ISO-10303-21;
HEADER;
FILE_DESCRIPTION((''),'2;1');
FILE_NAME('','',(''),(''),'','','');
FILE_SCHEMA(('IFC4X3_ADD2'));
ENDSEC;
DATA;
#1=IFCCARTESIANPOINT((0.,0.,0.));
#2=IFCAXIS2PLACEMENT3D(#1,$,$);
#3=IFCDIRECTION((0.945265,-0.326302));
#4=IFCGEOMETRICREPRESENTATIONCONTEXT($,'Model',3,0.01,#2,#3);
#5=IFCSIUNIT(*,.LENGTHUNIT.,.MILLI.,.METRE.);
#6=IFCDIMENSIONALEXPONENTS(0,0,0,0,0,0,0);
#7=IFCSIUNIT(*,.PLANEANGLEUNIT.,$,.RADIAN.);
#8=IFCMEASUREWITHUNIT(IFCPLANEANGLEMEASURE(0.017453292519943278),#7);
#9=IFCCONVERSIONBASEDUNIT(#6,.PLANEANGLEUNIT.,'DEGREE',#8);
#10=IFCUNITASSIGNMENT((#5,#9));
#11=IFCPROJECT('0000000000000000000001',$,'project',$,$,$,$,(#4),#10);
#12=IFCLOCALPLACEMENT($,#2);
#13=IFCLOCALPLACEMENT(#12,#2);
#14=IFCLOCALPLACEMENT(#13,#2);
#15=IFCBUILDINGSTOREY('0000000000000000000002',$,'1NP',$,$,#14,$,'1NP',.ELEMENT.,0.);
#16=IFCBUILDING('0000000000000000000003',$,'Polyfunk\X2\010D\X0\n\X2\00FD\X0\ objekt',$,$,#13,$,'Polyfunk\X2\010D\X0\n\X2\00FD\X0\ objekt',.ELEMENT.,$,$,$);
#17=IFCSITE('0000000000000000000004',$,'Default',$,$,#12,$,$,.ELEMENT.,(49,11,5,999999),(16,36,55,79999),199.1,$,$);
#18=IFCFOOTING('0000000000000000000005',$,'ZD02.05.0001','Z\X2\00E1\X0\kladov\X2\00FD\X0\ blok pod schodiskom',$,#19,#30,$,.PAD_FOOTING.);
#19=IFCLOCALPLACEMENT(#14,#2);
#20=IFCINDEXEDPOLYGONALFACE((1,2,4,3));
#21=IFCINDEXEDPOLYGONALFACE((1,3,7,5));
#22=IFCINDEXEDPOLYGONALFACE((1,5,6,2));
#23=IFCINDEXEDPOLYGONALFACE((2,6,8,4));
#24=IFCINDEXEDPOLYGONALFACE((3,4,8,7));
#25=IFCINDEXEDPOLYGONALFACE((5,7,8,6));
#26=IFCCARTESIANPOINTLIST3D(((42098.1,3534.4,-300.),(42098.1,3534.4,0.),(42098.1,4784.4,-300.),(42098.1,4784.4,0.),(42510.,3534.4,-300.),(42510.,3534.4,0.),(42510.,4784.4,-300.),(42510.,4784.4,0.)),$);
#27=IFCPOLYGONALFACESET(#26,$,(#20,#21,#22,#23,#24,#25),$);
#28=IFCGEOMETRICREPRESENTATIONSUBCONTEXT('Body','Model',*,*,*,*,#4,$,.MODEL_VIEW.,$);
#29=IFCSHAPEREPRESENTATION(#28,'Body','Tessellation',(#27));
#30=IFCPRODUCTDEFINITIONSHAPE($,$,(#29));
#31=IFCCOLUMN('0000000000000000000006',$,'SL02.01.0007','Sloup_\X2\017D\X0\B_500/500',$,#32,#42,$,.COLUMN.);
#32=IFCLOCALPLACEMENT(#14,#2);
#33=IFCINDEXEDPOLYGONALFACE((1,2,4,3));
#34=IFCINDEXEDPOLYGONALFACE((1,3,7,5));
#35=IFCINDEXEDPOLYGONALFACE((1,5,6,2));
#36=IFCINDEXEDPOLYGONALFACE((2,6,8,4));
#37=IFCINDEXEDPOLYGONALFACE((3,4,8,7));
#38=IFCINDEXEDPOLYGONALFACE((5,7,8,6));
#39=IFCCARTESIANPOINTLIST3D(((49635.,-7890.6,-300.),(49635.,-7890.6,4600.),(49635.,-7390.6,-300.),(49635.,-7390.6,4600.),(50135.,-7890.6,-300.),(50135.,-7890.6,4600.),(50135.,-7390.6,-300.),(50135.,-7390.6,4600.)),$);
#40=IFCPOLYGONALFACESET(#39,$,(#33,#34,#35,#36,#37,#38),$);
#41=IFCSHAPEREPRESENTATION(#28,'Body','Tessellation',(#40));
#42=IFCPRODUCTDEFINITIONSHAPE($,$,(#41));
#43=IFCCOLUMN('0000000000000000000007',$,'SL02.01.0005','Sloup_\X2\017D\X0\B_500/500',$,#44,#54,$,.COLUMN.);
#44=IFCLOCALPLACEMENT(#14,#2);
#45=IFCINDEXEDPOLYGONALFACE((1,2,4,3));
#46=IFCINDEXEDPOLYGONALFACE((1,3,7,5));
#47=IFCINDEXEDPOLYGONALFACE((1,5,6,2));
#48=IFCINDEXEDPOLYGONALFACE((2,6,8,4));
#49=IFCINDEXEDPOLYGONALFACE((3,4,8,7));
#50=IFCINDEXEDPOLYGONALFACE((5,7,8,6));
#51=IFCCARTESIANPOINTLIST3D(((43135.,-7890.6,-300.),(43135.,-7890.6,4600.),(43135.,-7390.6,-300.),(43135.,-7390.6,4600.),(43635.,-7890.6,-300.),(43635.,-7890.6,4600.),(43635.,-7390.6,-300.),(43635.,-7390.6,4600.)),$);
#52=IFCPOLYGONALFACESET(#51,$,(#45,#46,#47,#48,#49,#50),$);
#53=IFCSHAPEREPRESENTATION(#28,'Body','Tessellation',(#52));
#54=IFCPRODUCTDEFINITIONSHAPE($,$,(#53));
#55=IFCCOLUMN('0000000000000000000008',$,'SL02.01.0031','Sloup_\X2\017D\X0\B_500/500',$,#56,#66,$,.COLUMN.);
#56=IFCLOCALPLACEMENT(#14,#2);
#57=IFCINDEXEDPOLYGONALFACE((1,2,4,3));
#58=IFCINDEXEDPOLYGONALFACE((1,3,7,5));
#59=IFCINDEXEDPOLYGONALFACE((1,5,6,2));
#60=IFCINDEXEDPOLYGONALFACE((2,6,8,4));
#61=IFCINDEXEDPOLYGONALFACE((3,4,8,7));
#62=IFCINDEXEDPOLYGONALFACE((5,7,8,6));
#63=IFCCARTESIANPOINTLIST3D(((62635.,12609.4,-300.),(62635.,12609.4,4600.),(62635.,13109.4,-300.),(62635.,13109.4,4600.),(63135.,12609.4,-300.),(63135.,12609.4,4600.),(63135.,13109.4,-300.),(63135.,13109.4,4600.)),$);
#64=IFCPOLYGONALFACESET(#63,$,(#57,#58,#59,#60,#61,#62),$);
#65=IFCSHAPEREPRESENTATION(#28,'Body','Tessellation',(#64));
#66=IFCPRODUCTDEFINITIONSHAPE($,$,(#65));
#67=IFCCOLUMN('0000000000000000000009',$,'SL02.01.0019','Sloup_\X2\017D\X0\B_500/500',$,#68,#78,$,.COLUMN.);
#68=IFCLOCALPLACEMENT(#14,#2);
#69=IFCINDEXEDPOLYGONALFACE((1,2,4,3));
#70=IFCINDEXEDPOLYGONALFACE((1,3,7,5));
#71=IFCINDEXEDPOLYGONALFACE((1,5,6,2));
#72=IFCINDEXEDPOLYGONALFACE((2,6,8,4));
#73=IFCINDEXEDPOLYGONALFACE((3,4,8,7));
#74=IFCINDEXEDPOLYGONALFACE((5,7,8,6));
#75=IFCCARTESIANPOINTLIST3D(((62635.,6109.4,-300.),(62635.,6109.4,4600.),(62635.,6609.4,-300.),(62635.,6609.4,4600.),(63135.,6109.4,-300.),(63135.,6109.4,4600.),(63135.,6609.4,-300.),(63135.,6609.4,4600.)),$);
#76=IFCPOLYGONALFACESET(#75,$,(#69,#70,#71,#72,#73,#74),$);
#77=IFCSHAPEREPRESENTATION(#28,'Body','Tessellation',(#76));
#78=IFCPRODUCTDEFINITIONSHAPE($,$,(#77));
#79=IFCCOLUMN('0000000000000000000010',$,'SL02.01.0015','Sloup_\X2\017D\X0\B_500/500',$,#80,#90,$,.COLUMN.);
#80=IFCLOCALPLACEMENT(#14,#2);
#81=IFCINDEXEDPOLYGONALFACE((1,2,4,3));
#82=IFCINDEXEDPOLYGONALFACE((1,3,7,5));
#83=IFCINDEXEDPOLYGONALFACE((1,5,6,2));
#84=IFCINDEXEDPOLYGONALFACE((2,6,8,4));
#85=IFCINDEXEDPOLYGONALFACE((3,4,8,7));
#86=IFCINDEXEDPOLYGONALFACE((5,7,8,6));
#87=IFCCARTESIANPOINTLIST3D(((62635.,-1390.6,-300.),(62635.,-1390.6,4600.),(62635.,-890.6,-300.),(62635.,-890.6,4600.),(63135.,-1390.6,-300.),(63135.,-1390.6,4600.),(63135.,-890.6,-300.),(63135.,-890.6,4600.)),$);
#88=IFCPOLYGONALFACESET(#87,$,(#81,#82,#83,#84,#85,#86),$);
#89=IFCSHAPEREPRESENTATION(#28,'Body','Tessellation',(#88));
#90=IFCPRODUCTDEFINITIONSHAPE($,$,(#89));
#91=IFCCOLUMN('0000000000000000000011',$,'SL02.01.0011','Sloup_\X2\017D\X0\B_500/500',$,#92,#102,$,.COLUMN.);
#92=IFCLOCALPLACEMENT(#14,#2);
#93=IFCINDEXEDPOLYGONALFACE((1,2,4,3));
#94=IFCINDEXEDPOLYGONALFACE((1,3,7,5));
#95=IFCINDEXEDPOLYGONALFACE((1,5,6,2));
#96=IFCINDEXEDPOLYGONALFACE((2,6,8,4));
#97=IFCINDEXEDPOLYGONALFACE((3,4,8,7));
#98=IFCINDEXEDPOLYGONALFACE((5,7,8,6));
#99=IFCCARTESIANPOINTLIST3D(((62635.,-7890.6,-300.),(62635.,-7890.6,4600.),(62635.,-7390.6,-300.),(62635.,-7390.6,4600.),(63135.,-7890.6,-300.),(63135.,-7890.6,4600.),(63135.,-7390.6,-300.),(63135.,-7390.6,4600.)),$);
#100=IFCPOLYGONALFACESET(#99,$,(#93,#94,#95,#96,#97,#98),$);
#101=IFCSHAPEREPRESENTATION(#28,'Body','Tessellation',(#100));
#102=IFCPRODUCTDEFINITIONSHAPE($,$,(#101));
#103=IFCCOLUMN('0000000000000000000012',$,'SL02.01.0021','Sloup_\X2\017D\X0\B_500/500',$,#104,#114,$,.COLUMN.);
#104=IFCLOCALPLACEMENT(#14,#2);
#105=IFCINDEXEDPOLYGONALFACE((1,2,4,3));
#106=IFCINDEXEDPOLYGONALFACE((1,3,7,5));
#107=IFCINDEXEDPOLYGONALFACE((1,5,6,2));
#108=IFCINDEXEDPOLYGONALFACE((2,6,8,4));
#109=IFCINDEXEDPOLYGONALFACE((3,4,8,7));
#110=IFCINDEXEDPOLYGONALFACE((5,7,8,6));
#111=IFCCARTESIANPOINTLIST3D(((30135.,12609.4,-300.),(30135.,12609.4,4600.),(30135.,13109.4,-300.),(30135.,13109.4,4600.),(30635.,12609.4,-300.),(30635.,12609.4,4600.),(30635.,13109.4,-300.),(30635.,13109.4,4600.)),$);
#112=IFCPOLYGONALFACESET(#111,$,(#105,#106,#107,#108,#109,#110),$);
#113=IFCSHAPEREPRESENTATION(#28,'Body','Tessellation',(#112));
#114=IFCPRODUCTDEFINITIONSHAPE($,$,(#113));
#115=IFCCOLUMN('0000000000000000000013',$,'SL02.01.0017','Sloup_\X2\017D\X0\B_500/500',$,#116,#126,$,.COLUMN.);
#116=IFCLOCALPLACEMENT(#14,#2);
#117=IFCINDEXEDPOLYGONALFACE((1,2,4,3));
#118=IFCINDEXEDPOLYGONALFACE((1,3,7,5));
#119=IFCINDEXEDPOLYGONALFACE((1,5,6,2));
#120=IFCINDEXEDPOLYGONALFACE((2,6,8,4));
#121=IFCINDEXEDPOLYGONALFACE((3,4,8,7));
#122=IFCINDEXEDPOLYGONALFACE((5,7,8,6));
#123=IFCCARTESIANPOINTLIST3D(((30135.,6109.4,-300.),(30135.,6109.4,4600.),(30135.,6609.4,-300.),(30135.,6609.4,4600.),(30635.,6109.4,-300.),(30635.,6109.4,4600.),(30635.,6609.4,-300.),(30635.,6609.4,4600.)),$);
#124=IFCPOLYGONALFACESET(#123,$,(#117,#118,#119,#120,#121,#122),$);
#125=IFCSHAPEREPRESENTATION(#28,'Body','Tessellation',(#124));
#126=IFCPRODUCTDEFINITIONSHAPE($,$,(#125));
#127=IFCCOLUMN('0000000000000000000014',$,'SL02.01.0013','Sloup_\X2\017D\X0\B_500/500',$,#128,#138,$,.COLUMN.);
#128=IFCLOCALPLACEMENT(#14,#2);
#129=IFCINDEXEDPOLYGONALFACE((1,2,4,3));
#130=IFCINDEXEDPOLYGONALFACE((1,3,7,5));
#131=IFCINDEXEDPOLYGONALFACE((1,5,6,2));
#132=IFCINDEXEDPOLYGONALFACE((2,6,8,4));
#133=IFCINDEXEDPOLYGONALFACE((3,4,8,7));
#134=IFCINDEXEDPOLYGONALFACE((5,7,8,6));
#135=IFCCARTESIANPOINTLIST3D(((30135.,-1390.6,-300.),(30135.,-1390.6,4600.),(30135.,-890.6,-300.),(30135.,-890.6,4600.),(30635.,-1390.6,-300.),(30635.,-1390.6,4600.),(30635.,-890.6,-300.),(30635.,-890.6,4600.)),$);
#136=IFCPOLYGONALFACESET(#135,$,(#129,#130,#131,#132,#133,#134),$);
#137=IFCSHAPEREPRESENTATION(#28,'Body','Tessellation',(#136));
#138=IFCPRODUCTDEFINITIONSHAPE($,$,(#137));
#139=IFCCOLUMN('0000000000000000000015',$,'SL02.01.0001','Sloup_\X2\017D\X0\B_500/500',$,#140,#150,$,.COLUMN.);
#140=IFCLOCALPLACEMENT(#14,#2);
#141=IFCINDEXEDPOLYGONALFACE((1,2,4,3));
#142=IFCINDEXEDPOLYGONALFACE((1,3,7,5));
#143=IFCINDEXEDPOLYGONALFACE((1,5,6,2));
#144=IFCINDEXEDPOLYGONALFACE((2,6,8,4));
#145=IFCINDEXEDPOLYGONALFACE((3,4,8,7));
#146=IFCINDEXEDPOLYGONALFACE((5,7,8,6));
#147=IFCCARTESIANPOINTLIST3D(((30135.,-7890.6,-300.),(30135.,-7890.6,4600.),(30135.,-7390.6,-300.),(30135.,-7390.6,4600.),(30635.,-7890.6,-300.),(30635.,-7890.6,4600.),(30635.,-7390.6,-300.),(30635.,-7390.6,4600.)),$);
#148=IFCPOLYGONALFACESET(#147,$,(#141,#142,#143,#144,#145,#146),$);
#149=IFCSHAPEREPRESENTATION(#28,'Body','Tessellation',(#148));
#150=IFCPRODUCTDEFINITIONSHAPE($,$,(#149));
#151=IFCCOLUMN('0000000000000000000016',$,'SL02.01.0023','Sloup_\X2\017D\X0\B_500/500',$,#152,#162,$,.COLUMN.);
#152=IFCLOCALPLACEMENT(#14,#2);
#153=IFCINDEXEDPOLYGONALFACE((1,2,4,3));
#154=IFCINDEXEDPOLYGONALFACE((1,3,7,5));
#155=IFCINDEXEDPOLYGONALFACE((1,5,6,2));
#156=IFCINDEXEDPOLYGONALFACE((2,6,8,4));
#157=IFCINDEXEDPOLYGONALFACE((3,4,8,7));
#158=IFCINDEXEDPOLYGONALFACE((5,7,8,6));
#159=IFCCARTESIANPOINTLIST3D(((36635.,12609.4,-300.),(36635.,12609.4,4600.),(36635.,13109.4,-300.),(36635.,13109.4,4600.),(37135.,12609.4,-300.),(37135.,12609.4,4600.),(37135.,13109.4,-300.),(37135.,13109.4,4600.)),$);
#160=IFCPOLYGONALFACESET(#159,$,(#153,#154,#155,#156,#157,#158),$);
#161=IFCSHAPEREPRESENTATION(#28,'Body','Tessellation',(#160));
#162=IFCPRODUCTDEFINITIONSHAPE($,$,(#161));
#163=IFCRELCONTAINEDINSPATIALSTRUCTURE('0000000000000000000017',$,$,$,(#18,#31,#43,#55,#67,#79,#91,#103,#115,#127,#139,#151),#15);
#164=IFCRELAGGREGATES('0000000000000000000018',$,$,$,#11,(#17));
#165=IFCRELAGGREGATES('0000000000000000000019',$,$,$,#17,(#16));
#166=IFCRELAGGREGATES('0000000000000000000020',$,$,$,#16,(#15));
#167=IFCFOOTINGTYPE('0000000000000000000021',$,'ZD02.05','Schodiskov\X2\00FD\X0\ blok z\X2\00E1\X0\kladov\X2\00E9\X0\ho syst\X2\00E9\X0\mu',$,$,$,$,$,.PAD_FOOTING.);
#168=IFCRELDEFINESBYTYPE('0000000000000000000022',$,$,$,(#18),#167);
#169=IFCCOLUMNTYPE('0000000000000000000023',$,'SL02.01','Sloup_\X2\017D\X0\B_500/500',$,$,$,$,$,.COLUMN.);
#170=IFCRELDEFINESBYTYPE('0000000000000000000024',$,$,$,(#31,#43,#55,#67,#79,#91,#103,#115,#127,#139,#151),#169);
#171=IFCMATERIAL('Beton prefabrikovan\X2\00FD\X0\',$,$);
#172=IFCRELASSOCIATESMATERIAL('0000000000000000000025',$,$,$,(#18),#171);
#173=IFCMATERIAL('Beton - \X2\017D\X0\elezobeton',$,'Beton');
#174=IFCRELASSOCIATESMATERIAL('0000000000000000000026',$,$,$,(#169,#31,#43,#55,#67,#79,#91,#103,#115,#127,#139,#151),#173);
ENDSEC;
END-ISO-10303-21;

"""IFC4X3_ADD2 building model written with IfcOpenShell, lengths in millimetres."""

from ifc_helpers import new_model, entity, si_unit, converted_unit, direction, frame, frame_2d, origin, origin_2d_with_axis, place, context, subcontext, project, spatial, rectangle, extrude, source, transform, mapped, material, material_profile, profile_set, profile_usage, type_object, element, save


model = new_model("IFC4X3_ADD2")

# Units and contexts
model_context = context("Model", 3, precision=0.01, world=origin(), true_north=direction((0.945265, -0.326302)))
body_context = subcontext(model_context, "Body", "Model", "MODEL_VIEW")
ifc_project = project(units=[si_unit("LENGTHUNIT", "METRE", prefix="MILLI"), converted_unit("PLANEANGLEUNIT", "DEGREE", entity("IfcPlaneAngleMeasure", 0.017453292519943278), si_unit("PLANEANGLEUNIT", "RADIAN"), dimensions=[0, 0, 0, 0, 0, 0, 0])], contexts=[model_context])

# Site, building, storey
site_placement = place(None, origin())
site = spatial("IfcSite", under=ifc_project, at=site_placement, Name="Default", CompositionType="ELEMENT", RefLatitude=(49, 11, 5, 999999), RefLongitude=(16, 36, 55, 79999), RefElevation=199.1)
building_placement = place(site_placement, origin())
building = spatial("IfcBuilding", under=site, at=building_placement, Name="Polyfunkčný objekt", LongName="Polyfunkčný objekt", CompositionType="ELEMENT")
storey_placement = place(building_placement, origin())
storey = spatial("IfcBuildingStorey", under=building, at=storey_placement, Name="1NP", LongName="1NP", CompositionType="ELEMENT", Elevation=0.0)

# Footing
ifc_material_1 = material(Name="Beton prefabrikovaný")
footing_type = type_object("IfcFootingType", Name="ZD02.05", Description="Schodiskový blok základového systému", PredefinedType="PAD_FOOTING")
footing_placement = place(storey_placement, origin())
element("IfcFooting", 1, at=footing_placement, inside=storey, type_object=footing_type, material=ifc_material_1, Name="ZD02.05.0001", Description="Základový blok pod schodiskom", PredefinedType="PAD_FOOTING", context=body_context, shape_type="SweptSolid", body=[
    extrude(rectangle(XDim=1250.0, YDim=411.8, at=frame_2d((0.0, 0.0), x_axis=(1.0, 0.0))), frame((42304.0, 4159.4, -300.0), z_axis=(0.0, 0.0, 1.0), x_axis=(0.0, -1.0, 0.0)), (0.0, 0.0, 1.0), 300.0),
])

# Columns
ifc_material_2 = material(Name="Beton - Železobeton", Category="Beton")
ifc_material_profile = material_profile(ifc_material_2, rectangle(XDim=500.0, YDim=500.0, at=frame_2d((0.0, 0.0), x_axis=(1.0, 0.0))), Name="Sloup_ŽB_500/500")
ifc_profile_set = profile_set([ifc_material_profile], Name="Sloup_ŽB_500/500")
ifc_profile_usage = profile_usage(ifc_profile_set)
column_type = type_object("IfcColumnType", Name="SL02.01", Description="Sloup_ŽB_500/500", PredefinedType="COLUMN", material=ifc_profile_set)
shared_shape_1 = source(origin(), body_context, "Body", "SweptSolid", [
    extrude(rectangle(XDim=500.0, YDim=500.0, at=frame_2d((0.0, 0.0), x_axis=(1.0, 0.0))), frame((49885.0, -7640.6, -300.0)), (0.0, 0.0, 1.0), 4900.0),
])
column_1_placement = place(storey_placement, origin())
element("IfcColumn", 2, at=column_1_placement, inside=storey, type_object=column_type, material=ifc_profile_usage, Name="SL02.01.0007", Description="Sloup_ŽB_500/500", PredefinedType="COLUMN", context=body_context, shape_type="MappedRepresentation", body=[
    mapped(shared_shape_1, transform((0.0, 0.0, 0.0), scale=1.0)),
])
shared_shape_2 = source(origin(), body_context, "Body", "SweptSolid", [
    extrude(rectangle(XDim=500.0, YDim=500.0, at=origin_2d_with_axis()), frame((43385.0, -7640.6, -300.0)), (0.0, 0.0, 1.0), 4900.0),
])
column_2_placement = place(storey_placement, origin())
element("IfcColumn", 3, at=column_2_placement, inside=storey, type_object=column_type, material=ifc_profile_usage, Name="SL02.01.0005", Description="Sloup_ŽB_500/500", PredefinedType="COLUMN", context=body_context, shape_type="MappedRepresentation", body=[
    mapped(shared_shape_2, transform((0.0, 0.0, 0.0), scale=1.0)),
])
shared_shape_3 = source(origin(), body_context, "Body", "SweptSolid", [
    extrude(rectangle(XDim=500.0, YDim=500.0, at=origin_2d_with_axis()), frame((62885.0, 12859.4, -300.0), z_axis=(0.0, 0.0, 1.0), x_axis=(-1.0, 0.0, 0.0)), (0.0, 0.0, 1.0), 4900.0),
])
column_3_placement = place(storey_placement, origin())
element("IfcColumn", 4, at=column_3_placement, inside=storey, type_object=column_type, material=ifc_profile_usage, Name="SL02.01.0031", Description="Sloup_ŽB_500/500", PredefinedType="COLUMN", context=body_context, shape_type="MappedRepresentation", body=[
    mapped(shared_shape_3, transform((0.0, 0.0, 0.0), scale=1.0)),
])
shared_shape_4 = source(origin(), body_context, "Body", "SweptSolid", [
    extrude(rectangle(XDim=500.0, YDim=500.0, at=origin_2d_with_axis()), frame((62885.0, 6359.4, -300.0), z_axis=(0.0, 0.0, 1.0), x_axis=(0.0, -1.0, 0.0)), (0.0, 0.0, 1.0), 4900.0),
])
column_4_placement = place(storey_placement, origin())
element("IfcColumn", 5, at=column_4_placement, inside=storey, type_object=column_type, material=ifc_profile_usage, Name="SL02.01.0019", Description="Sloup_ŽB_500/500", PredefinedType="COLUMN", context=body_context, shape_type="MappedRepresentation", body=[
    mapped(shared_shape_4, transform((0.0, 0.0, 0.0), scale=1.0)),
])
shared_shape_5 = source(origin(), body_context, "Body", "SweptSolid", [
    extrude(rectangle(XDim=500.0, YDim=500.0, at=origin_2d_with_axis()), frame((62885.0, -1140.6, -300.0), z_axis=(0.0, 0.0, 1.0), x_axis=(0.0, -1.0, 0.0)), (0.0, 0.0, 1.0), 4900.0),
])
column_5_placement = place(storey_placement, origin())
element("IfcColumn", 6, at=column_5_placement, inside=storey, type_object=column_type, material=ifc_profile_usage, Name="SL02.01.0015", Description="Sloup_ŽB_500/500", PredefinedType="COLUMN", context=body_context, shape_type="MappedRepresentation", body=[
    mapped(shared_shape_5, transform((0.0, 0.0, 0.0), scale=1.0)),
])
shared_shape_6 = source(origin(), body_context, "Body", "SweptSolid", [
    extrude(rectangle(XDim=500.0, YDim=500.0, at=origin_2d_with_axis()), frame((62885.0, -7640.6, -300.0), z_axis=(0.0, 0.0, 1.0), x_axis=(-1.0, 0.0, 0.0)), (0.0, 0.0, 1.0), 4900.0),
])
column_6_placement = place(storey_placement, origin())
element("IfcColumn", 7, at=column_6_placement, inside=storey, type_object=column_type, material=ifc_profile_usage, Name="SL02.01.0011", Description="Sloup_ŽB_500/500", PredefinedType="COLUMN", context=body_context, shape_type="MappedRepresentation", body=[
    mapped(shared_shape_6, transform((0.0, 0.0, 0.0), scale=1.0)),
])
shared_shape_7 = source(origin(), body_context, "Body", "SweptSolid", [
    extrude(rectangle(XDim=500.0, YDim=500.0, at=origin_2d_with_axis()), frame((30385.0, 12859.4, -300.0), z_axis=(0.0, 0.0, 1.0), x_axis=(-1.0, 0.0, 0.0)), (0.0, 0.0, 1.0), 4900.0),
])
column_7_placement = place(storey_placement, origin())
element("IfcColumn", 8, at=column_7_placement, inside=storey, type_object=column_type, material=ifc_profile_usage, Name="SL02.01.0021", Description="Sloup_ŽB_500/500", PredefinedType="COLUMN", context=body_context, shape_type="MappedRepresentation", body=[
    mapped(shared_shape_7, transform((0.0, 0.0, 0.0), scale=1.0)),
])
shared_shape_8 = source(origin(), body_context, "Body", "SweptSolid", [
    extrude(rectangle(XDim=500.0, YDim=500.0, at=frame_2d((0.0, 0.0), x_axis=(1.0, 0.0))), frame((30385.0, 6359.4, -300.0), z_axis=(0.0, 0.0, 1.0), x_axis=(0.0, -1.0, 0.0)), (0.0, 0.0, 1.0), 4900.0),
])
column_8_placement = place(storey_placement, origin())
element("IfcColumn", 9, at=column_8_placement, inside=storey, type_object=column_type, material=ifc_profile_usage, Name="SL02.01.0017", Description="Sloup_ŽB_500/500", PredefinedType="COLUMN", context=body_context, shape_type="MappedRepresentation", body=[
    mapped(shared_shape_8, transform((0.0, 0.0, 0.0), scale=1.0)),
])
shared_shape_9 = source(origin(), body_context, "Body", "SweptSolid", [
    extrude(rectangle(XDim=500.0, YDim=500.0, at=origin_2d_with_axis()), frame((30385.0, -1140.6, -300.0), z_axis=(0.0, 0.0, 1.0), x_axis=(0.0, -1.0, 0.0)), (0.0, 0.0, 1.0), 4900.0),
])
column_9_placement = place(storey_placement, origin())
element("IfcColumn", 10, at=column_9_placement, inside=storey, type_object=column_type, material=ifc_profile_usage, Name="SL02.01.0013", Description="Sloup_ŽB_500/500", PredefinedType="COLUMN", context=body_context, shape_type="MappedRepresentation", body=[
    mapped(shared_shape_9, transform((0.0, 0.0, 0.0), scale=1.0)),
])
shared_shape_10 = source(origin(), body_context, "Body", "SweptSolid", [
    extrude(rectangle(XDim=500.0, YDim=500.0, at=frame_2d((0.0, 0.0), x_axis=(1.0, 0.0))), frame((30385.0, -7640.6, -300.0), z_axis=(0.0, 0.0, 1.0), x_axis=(-1.0, 0.0, 0.0)), (0.0, 0.0, 1.0), 4900.0),
])
column_10_placement = place(storey_placement, origin())
element("IfcColumn", 11, at=column_10_placement, inside=storey, type_object=column_type, material=ifc_profile_usage, Name="SL02.01.0001", Description="Sloup_ŽB_500/500", PredefinedType="COLUMN", context=body_context, shape_type="MappedRepresentation", body=[
    mapped(shared_shape_10, transform((0.0, 0.0, 0.0), scale=1.0)),
])
shared_shape_11 = source(origin(), body_context, "Body", "SweptSolid", [
    extrude(rectangle(XDim=500.0, YDim=500.0, at=frame_2d((-83.3, 0.0), x_axis=(1.0, 0.0))), frame((36885.0, 12776.1, -300.0), z_axis=(0.0, 0.0, 1.0), x_axis=(0.0, -1.0, 0.0)), (0.0, 0.0, 1.0), 4900.0),
])
column_11_placement = place(storey_placement, origin())
element("IfcColumn", 12, at=column_11_placement, inside=storey, type_object=column_type, material=ifc_profile_usage, Name="SL02.01.0023", Description="Sloup_ŽB_500/500", PredefinedType="COLUMN", context=body_context, shape_type="MappedRepresentation", body=[
    mapped(shared_shape_11, transform((0.0, 0.0, 0.0), scale=1.0)),
])

save(model, "model.ifc")
